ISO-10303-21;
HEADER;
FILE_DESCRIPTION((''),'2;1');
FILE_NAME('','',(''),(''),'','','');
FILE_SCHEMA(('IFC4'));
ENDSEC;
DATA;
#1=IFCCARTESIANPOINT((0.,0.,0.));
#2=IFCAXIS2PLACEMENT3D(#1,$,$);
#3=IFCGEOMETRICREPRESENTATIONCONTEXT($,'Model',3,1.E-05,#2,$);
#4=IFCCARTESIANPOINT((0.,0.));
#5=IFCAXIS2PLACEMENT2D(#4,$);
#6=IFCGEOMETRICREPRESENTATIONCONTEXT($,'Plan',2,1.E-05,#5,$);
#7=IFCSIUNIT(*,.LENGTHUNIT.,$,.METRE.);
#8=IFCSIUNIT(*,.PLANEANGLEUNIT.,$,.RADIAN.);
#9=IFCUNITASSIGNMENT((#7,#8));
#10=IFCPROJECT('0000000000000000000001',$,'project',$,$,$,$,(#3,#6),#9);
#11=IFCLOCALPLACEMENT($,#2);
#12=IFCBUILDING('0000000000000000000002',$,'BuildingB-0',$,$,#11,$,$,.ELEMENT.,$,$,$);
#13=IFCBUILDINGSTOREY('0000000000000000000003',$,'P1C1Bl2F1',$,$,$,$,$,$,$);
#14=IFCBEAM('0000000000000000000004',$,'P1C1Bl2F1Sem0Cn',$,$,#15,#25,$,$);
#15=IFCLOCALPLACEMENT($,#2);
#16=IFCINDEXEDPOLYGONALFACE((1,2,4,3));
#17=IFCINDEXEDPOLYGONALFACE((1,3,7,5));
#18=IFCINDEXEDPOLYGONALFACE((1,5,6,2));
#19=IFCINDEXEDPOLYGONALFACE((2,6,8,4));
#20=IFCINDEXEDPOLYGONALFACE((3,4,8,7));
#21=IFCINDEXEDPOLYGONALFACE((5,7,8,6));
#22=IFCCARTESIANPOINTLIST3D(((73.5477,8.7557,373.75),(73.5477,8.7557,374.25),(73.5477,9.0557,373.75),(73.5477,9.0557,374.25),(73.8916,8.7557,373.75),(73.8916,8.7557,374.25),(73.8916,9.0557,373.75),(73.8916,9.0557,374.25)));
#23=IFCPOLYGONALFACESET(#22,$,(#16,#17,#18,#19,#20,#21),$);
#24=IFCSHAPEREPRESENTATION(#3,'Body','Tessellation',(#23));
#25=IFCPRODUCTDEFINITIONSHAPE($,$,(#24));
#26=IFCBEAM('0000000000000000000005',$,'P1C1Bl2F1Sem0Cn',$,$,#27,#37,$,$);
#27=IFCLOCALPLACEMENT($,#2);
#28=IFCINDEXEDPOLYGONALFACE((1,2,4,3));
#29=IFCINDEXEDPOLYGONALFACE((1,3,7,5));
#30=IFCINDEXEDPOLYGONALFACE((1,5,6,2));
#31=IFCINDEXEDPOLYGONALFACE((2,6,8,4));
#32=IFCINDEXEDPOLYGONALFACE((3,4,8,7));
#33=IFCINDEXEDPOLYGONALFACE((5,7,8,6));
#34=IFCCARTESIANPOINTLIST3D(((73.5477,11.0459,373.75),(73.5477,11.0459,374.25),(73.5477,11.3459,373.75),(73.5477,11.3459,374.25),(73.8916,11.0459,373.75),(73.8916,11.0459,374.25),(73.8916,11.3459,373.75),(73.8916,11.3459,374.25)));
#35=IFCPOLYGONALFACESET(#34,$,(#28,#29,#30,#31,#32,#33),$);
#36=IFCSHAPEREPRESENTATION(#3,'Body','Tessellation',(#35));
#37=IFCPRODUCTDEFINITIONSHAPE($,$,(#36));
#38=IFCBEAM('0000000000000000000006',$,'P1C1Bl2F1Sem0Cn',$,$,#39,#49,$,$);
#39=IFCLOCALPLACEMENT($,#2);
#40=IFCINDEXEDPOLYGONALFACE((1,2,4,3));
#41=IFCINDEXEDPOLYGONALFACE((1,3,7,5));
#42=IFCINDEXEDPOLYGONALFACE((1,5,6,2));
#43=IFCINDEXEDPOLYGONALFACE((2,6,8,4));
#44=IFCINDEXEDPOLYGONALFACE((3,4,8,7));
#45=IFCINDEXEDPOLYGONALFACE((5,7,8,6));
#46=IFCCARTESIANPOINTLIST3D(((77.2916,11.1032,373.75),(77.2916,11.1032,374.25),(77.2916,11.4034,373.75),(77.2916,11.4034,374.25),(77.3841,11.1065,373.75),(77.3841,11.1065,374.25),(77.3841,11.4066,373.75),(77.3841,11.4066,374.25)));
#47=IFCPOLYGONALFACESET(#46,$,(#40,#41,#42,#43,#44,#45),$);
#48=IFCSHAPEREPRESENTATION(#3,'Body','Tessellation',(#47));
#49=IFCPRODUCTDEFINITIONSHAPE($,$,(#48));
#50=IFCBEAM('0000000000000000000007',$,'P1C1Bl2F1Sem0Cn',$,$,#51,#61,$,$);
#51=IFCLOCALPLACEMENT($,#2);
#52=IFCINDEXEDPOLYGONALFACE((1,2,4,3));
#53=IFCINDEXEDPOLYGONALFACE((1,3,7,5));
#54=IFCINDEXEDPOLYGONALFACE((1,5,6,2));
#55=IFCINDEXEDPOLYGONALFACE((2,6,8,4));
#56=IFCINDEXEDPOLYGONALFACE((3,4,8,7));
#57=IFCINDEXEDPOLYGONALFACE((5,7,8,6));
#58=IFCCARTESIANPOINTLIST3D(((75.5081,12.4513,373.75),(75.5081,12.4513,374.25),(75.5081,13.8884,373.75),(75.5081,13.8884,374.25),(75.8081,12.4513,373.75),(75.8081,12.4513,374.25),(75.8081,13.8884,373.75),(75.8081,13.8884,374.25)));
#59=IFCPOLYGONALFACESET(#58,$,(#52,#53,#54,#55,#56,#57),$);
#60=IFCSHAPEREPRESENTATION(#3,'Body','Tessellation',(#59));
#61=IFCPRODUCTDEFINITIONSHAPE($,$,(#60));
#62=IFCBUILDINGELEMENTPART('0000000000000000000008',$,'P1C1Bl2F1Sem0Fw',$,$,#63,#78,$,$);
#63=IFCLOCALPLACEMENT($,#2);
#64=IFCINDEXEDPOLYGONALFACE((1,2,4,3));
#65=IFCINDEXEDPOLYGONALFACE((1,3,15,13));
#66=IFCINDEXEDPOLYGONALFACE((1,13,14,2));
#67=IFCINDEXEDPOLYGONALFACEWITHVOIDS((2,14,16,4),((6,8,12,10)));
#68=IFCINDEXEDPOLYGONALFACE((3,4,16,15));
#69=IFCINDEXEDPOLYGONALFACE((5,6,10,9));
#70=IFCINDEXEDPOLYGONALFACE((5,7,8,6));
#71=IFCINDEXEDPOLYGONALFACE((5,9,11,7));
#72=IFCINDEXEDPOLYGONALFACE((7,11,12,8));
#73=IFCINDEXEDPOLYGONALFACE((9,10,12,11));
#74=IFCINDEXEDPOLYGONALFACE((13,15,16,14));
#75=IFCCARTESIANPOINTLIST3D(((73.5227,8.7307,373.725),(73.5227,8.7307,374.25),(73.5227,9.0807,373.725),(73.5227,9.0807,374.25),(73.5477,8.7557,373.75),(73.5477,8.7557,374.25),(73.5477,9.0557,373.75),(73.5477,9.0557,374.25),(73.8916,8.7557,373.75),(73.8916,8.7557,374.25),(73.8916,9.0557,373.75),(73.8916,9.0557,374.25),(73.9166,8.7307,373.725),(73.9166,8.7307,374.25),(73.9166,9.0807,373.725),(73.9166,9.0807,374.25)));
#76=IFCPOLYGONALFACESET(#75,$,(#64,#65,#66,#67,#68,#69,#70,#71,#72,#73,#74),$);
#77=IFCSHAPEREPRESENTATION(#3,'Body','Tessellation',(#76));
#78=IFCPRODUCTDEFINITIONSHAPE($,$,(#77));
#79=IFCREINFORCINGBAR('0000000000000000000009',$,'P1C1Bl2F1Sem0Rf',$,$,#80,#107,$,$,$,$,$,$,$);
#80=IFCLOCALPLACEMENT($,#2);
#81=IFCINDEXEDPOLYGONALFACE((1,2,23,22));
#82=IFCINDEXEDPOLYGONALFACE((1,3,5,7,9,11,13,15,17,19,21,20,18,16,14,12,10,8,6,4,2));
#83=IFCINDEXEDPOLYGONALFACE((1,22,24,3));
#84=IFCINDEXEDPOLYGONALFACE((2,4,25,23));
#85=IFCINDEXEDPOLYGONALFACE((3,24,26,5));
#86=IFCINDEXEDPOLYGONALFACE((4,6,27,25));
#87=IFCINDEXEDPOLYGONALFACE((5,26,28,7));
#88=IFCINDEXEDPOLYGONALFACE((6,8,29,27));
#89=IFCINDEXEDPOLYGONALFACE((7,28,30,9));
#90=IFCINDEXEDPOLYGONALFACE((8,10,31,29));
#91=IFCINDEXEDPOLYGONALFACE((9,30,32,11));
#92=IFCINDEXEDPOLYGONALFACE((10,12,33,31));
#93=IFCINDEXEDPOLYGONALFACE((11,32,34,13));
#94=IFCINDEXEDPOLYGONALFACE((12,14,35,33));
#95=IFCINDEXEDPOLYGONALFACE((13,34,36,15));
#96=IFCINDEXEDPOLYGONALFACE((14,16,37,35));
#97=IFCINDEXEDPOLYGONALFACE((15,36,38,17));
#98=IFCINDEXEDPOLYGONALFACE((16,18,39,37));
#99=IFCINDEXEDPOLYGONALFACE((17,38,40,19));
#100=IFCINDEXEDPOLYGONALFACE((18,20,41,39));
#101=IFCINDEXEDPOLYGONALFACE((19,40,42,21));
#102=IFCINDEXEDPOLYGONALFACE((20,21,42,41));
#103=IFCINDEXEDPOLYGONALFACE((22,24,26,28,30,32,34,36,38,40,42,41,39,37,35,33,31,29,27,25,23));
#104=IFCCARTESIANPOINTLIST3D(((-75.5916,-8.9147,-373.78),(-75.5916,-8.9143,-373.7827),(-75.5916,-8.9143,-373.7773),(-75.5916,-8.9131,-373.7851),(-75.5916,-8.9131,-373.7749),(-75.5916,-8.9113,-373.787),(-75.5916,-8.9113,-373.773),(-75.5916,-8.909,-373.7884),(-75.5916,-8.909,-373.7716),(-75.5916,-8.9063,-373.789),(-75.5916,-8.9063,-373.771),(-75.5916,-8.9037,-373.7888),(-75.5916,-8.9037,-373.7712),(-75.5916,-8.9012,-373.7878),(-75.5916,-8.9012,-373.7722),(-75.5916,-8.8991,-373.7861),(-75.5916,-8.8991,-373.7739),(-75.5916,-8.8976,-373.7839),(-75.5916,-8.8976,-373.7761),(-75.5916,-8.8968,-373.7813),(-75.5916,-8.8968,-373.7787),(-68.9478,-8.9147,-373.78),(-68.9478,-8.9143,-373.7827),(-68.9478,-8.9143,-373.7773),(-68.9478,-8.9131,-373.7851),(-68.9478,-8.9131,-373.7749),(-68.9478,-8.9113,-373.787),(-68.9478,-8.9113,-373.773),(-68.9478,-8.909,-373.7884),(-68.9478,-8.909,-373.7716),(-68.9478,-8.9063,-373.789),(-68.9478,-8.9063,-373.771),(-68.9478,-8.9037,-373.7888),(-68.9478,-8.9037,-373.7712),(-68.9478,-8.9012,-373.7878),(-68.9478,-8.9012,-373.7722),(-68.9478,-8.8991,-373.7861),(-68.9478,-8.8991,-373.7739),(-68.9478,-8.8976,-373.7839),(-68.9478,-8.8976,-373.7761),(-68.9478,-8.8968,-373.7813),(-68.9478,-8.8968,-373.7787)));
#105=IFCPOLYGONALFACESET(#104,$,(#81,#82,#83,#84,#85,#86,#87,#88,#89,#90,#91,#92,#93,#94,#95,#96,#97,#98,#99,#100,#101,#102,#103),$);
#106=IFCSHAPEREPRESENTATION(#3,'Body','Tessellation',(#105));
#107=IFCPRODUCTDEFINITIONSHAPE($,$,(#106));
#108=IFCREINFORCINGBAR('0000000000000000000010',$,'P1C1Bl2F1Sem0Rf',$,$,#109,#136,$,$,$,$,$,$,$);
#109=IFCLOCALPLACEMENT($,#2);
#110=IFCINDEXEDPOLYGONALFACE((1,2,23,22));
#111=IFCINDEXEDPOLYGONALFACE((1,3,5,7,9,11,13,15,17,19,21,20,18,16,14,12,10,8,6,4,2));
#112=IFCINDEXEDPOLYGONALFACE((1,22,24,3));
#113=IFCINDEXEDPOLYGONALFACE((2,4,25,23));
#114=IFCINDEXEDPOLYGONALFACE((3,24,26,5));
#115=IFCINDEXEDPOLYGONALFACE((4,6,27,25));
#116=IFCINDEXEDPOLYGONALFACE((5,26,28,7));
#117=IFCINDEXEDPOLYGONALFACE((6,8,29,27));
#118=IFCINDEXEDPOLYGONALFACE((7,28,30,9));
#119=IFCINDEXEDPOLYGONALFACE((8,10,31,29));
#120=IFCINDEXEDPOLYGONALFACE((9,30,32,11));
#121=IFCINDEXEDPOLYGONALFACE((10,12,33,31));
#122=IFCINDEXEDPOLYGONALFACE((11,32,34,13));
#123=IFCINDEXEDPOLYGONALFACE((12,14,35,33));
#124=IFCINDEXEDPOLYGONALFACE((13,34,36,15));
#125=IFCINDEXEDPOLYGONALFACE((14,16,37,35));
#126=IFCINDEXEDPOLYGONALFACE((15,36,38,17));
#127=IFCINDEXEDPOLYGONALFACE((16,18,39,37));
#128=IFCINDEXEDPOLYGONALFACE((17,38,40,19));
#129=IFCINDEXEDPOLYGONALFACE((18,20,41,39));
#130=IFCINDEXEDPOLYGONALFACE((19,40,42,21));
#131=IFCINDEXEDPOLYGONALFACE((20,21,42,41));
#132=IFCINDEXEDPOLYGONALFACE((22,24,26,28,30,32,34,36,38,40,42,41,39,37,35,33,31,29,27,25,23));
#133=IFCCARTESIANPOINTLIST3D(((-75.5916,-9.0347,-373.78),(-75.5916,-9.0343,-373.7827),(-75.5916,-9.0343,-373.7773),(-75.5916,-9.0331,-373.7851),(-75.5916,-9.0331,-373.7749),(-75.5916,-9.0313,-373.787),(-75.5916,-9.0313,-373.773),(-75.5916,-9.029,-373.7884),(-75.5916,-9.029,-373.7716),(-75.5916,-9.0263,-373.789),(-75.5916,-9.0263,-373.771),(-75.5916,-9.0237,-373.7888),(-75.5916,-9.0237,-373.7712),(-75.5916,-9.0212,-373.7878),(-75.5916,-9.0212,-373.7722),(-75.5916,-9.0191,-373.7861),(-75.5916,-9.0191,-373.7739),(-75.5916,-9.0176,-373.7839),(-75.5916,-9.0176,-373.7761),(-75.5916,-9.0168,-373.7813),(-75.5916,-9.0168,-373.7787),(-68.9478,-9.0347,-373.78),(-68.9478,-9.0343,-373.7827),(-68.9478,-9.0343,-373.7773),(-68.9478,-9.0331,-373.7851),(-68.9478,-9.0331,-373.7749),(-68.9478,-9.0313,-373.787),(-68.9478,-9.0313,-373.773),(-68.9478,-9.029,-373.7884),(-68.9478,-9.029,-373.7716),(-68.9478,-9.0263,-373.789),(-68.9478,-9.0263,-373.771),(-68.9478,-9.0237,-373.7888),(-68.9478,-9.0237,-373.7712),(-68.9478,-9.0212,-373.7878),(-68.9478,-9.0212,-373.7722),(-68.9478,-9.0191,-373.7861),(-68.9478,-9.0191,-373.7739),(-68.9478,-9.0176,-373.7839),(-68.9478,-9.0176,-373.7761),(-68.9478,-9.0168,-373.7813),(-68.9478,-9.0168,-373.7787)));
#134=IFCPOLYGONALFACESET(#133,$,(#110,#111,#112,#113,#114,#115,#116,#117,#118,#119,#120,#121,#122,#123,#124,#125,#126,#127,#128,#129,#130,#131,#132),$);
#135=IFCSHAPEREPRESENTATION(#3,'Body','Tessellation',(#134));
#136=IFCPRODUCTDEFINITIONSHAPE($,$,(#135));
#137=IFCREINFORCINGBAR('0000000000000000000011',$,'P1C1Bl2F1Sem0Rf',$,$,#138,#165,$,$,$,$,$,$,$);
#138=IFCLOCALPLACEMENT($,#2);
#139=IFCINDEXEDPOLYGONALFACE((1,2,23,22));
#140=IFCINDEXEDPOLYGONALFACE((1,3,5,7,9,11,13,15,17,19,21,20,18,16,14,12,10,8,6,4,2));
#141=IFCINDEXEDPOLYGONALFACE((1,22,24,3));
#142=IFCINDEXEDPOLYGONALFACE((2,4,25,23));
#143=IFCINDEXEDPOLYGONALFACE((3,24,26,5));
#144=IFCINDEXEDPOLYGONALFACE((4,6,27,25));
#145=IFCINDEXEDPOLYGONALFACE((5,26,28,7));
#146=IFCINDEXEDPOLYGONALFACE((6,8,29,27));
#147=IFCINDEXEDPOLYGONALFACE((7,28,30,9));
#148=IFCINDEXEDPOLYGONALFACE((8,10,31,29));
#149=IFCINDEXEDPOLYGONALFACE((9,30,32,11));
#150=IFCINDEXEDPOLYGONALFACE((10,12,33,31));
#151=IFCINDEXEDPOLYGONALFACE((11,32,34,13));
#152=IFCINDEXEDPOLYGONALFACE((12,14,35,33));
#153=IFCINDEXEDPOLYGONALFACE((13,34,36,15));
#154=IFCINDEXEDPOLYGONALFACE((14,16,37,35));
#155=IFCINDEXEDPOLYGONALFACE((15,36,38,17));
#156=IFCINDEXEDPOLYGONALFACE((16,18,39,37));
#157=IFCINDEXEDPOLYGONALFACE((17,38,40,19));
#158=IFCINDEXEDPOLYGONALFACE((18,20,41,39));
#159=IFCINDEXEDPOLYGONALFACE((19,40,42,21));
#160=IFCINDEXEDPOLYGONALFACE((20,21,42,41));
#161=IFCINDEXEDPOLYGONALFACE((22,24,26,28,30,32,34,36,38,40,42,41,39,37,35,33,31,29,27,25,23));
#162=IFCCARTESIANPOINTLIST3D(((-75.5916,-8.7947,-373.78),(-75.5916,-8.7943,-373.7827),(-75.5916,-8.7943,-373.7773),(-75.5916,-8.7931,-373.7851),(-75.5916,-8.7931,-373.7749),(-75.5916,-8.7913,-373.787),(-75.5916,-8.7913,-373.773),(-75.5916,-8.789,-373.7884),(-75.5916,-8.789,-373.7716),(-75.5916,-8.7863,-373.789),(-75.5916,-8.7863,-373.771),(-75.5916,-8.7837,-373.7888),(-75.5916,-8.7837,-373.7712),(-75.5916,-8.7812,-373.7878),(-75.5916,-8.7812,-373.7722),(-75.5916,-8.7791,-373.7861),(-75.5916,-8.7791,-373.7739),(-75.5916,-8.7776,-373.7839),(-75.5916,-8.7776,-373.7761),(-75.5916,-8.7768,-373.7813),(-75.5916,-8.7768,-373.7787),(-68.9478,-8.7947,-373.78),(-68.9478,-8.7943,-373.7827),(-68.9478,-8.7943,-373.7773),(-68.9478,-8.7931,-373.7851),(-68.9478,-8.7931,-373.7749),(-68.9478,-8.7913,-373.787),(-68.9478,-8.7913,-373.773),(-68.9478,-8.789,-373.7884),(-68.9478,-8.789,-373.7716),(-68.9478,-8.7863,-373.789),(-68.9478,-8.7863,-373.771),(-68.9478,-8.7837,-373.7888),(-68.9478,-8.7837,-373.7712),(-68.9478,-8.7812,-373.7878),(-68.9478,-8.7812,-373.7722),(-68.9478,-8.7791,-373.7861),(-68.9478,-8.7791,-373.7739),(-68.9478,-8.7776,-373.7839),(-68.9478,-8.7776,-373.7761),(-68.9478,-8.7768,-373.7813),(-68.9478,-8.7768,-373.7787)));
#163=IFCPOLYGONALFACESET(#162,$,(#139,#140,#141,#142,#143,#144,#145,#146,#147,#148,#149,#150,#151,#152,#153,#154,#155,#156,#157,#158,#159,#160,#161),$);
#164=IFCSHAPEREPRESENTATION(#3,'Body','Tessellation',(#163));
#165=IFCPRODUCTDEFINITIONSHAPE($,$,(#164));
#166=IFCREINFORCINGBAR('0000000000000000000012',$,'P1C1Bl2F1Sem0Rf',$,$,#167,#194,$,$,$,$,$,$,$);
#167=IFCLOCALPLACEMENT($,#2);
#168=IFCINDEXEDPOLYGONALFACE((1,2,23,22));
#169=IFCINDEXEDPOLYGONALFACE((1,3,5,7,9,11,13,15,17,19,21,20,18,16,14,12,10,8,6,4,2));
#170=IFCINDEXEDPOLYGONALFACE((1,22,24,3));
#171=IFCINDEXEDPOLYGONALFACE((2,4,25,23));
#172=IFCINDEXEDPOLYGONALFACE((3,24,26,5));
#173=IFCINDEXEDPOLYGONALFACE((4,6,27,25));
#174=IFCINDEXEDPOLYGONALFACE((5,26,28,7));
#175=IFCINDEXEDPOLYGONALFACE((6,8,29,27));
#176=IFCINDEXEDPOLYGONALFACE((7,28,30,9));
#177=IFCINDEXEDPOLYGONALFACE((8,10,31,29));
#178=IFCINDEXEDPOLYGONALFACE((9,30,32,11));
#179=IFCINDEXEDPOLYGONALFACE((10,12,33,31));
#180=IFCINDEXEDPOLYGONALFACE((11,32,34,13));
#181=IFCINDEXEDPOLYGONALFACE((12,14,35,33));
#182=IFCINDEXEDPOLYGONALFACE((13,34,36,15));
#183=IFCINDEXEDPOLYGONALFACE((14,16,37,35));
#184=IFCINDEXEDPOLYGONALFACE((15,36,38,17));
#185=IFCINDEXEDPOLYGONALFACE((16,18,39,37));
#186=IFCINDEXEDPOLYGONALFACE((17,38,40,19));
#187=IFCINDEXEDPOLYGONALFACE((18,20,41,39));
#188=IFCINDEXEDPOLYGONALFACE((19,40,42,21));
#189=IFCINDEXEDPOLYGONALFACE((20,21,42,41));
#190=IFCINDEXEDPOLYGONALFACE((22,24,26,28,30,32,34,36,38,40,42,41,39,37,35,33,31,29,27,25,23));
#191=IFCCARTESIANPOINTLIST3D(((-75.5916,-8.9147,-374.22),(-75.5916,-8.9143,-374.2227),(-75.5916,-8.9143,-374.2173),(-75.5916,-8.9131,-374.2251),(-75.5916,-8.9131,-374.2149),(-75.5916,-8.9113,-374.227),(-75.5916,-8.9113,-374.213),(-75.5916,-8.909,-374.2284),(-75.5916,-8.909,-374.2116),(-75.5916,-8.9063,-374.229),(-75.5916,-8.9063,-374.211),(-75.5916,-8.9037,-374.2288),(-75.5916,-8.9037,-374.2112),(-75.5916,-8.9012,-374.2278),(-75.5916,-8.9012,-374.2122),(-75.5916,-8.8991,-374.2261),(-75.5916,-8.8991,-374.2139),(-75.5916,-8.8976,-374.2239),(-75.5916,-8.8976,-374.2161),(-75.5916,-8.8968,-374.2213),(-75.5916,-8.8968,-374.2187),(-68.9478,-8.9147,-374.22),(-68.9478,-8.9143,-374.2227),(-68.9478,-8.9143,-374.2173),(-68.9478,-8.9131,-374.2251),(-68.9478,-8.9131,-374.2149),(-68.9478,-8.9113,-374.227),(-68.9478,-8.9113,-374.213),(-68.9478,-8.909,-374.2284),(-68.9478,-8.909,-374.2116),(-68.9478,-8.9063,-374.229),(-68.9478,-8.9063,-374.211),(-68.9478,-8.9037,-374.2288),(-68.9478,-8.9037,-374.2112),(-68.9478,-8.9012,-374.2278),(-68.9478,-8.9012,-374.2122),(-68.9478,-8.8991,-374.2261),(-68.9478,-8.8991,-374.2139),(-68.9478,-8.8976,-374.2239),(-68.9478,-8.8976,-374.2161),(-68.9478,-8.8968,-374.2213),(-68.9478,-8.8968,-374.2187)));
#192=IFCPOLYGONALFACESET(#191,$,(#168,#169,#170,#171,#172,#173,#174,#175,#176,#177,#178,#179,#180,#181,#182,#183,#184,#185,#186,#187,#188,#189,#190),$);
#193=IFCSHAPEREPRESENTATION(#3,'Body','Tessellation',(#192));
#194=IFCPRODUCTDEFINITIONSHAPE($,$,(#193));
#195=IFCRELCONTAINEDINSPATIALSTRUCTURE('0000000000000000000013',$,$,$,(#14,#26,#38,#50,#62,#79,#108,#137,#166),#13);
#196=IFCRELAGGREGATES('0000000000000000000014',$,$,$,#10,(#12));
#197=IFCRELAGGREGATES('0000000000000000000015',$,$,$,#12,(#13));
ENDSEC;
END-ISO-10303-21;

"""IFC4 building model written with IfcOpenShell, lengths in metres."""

from ifc_helpers import new_model, entity, si_unit, origin, origin_2d, place, context, project, spatial, polyline, outline, extrude, element, save


model = new_model("IFC4")

# Units and contexts
model_context = context("Model", 3, precision=1e-05, world=origin())
plan_context = context("Plan", 2, precision=1e-05, world=origin_2d())
ifc_project = project(units=[si_unit("LENGTHUNIT", "METRE"), si_unit("PLANEANGLEUNIT", "RADIAN")], contexts=[model_context, plan_context])

# Building, storey
building_placement = place(None, origin())
building = spatial("IfcBuilding", under=ifc_project, at=building_placement, Name="BuildingB-0", CompositionType="ELEMENT")
storey = spatial("IfcBuildingStorey", under=building, Name="P1C1Bl2F1")

# Beams
element("IfcBeam", 1, inside=storey, Name="P1C1Bl2F1Sem0Cn", context=model_context, shape_type="SweptSolid", body=[
    extrude(outline(polyline([(73.8916, 8.7557, 373.75), (73.5477, 8.7557, 373.75), (73.5477, 9.0557, 373.75), (73.8916, 9.0557, 373.75), (73.8916, 8.7557, 373.75)])), None, (0.0, 0.0, 1.0), 0.5),
])
element("IfcBeam", 2, inside=storey, Name="P1C1Bl2F1Sem0Cn", context=model_context, shape_type="SweptSolid", body=[
    extrude(outline(polyline([(73.8916, 11.0459, 373.75), (73.5477, 11.0459, 373.75), (73.5477, 11.3459, 373.75), (73.8916, 11.3459, 373.75), (73.8916, 11.0459, 373.75)])), None, (0.0, 0.0, 1.0), 0.5),
])
element("IfcBeam", 3, inside=storey, Name="P1C1Bl2F1Sem0Cn", context=model_context, shape_type="SweptSolid", body=[
    extrude(outline(polyline([(77.3841, 11.1065, 373.75), (77.2916, 11.1032, 373.75), (77.2916, 11.4034, 373.75), (77.3841, 11.4066, 373.75), (77.3841, 11.1065, 373.75)])), None, (0.0, 0.0, 1.0), 0.5),
])
element("IfcBeam", 4, inside=storey, Name="P1C1Bl2F1Sem0Cn", context=model_context, shape_type="SweptSolid", body=[
    extrude(outline(polyline([(75.8081, 12.4513, 373.75), (75.5081, 12.4513, 373.75), (75.5081, 13.8884, 373.75), (75.8081, 13.8884, 373.75), (75.8081, 12.4513, 373.75)])), None, (0.0, 0.0, 1.0), 0.5),
])

# Building element part, opening
building_element_part_1 = element("IfcBuildingElementPart", 5, inside=storey, Name="P1C1Bl2F1Sem0Fw", context=model_context, shape_type="SweptSolid", body=[
    extrude(outline(polyline([(73.9166, 8.7307, 373.725), (73.5227, 8.7307, 373.725), (73.5227, 9.0807, 373.725), (73.9166, 9.0807, 373.725), (73.9166, 8.7307, 373.725)])), None, (0.0, 0.0, 1.0), 0.525),
])
element("IfcOpeningElement", 6, inside=storey, cuts=building_element_part_1, context=model_context, shape_type="SweptSolid", body=[
    extrude(outline(polyline([(73.8916, 8.7557, 373.75), (73.5477, 8.7557, 373.75), (73.5477, 9.0557, 373.75), (73.8916, 9.0557, 373.75), (73.8916, 8.7557, 373.75)])), None, (0.0, 0.0, 1.0), 0.5),
])

# Reinforcing bars
element("IfcReinforcingBar", 7, inside=storey, Name="P1C1Bl2F1Sem0Rf", context=model_context, shape_type="SweptSolid", body=[
    entity("IfcSurfaceCurveSweptAreaSolid", entity("IfcCircleProfileDef", "AREA", None, None, 0.009), None, entity("IfcPolyline", [entity("IfcCartesianPoint", [75.5916, 8.9057, 373.78]), entity("IfcCartesianPoint", [68.9478, 8.9057, 373.78])]), None, None, entity("IfcPlane", entity("IfcAxis2Placement3D", entity("IfcCartesianPoint", [75.5916, 8.9057, 373.78]), entity("IfcDirection", [0.0, 0.0, 1.0]), entity("IfcDirection", [1.0, 0.0, 0.0])))),
])
element("IfcReinforcingBar", 8, inside=storey, Name="P1C1Bl2F1Sem0Rf", context=model_context, shape_type="SweptSolid", body=[
    entity("IfcSurfaceCurveSweptAreaSolid", entity("IfcCircleProfileDef", "AREA", None, None, 0.009), None, entity("IfcPolyline", [entity("IfcCartesianPoint", [75.5916, 9.0257, 373.78]), entity("IfcCartesianPoint", [68.9478, 9.0257, 373.78])]), None, None, entity("IfcPlane", entity("IfcAxis2Placement3D", entity("IfcCartesianPoint", [75.5916, 9.0257, 373.78]), entity("IfcDirection", [0.0, 0.0, 1.0]), entity("IfcDirection", [1.0, 0.0, 0.0])))),
])
element("IfcReinforcingBar", 9, inside=storey, Name="P1C1Bl2F1Sem0Rf", context=model_context, shape_type="SweptSolid", body=[
    entity("IfcSurfaceCurveSweptAreaSolid", entity("IfcCircleProfileDef", "AREA", None, None, 0.009), None, entity("IfcPolyline", [entity("IfcCartesianPoint", [75.5916, 8.7857, 373.78]), entity("IfcCartesianPoint", [68.9478, 8.7857, 373.78])]), None, None, entity("IfcPlane", entity("IfcAxis2Placement3D", entity("IfcCartesianPoint", [75.5916, 8.7857, 373.78]), entity("IfcDirection", [0.0, 0.0, 1.0]), entity("IfcDirection", [1.0, 0.0, 0.0])))),
])
element("IfcReinforcingBar", 10, inside=storey, Name="P1C1Bl2F1Sem0Rf", context=model_context, shape_type="SweptSolid", body=[
    entity("IfcSurfaceCurveSweptAreaSolid", entity("IfcCircleProfileDef", "AREA", None, None, 0.009), None, entity("IfcPolyline", [entity("IfcCartesianPoint", [75.5916, 8.9057, 374.22]), entity("IfcCartesianPoint", [68.9478, 8.9057, 374.22])]), None, None, entity("IfcPlane", entity("IfcAxis2Placement3D", entity("IfcCartesianPoint", [75.5916, 8.9057, 374.22]), entity("IfcDirection", [0.0, 0.0, 1.0]), entity("IfcDirection", [1.0, 0.0, 0.0])))),
])

save(model, "model.ifc")
